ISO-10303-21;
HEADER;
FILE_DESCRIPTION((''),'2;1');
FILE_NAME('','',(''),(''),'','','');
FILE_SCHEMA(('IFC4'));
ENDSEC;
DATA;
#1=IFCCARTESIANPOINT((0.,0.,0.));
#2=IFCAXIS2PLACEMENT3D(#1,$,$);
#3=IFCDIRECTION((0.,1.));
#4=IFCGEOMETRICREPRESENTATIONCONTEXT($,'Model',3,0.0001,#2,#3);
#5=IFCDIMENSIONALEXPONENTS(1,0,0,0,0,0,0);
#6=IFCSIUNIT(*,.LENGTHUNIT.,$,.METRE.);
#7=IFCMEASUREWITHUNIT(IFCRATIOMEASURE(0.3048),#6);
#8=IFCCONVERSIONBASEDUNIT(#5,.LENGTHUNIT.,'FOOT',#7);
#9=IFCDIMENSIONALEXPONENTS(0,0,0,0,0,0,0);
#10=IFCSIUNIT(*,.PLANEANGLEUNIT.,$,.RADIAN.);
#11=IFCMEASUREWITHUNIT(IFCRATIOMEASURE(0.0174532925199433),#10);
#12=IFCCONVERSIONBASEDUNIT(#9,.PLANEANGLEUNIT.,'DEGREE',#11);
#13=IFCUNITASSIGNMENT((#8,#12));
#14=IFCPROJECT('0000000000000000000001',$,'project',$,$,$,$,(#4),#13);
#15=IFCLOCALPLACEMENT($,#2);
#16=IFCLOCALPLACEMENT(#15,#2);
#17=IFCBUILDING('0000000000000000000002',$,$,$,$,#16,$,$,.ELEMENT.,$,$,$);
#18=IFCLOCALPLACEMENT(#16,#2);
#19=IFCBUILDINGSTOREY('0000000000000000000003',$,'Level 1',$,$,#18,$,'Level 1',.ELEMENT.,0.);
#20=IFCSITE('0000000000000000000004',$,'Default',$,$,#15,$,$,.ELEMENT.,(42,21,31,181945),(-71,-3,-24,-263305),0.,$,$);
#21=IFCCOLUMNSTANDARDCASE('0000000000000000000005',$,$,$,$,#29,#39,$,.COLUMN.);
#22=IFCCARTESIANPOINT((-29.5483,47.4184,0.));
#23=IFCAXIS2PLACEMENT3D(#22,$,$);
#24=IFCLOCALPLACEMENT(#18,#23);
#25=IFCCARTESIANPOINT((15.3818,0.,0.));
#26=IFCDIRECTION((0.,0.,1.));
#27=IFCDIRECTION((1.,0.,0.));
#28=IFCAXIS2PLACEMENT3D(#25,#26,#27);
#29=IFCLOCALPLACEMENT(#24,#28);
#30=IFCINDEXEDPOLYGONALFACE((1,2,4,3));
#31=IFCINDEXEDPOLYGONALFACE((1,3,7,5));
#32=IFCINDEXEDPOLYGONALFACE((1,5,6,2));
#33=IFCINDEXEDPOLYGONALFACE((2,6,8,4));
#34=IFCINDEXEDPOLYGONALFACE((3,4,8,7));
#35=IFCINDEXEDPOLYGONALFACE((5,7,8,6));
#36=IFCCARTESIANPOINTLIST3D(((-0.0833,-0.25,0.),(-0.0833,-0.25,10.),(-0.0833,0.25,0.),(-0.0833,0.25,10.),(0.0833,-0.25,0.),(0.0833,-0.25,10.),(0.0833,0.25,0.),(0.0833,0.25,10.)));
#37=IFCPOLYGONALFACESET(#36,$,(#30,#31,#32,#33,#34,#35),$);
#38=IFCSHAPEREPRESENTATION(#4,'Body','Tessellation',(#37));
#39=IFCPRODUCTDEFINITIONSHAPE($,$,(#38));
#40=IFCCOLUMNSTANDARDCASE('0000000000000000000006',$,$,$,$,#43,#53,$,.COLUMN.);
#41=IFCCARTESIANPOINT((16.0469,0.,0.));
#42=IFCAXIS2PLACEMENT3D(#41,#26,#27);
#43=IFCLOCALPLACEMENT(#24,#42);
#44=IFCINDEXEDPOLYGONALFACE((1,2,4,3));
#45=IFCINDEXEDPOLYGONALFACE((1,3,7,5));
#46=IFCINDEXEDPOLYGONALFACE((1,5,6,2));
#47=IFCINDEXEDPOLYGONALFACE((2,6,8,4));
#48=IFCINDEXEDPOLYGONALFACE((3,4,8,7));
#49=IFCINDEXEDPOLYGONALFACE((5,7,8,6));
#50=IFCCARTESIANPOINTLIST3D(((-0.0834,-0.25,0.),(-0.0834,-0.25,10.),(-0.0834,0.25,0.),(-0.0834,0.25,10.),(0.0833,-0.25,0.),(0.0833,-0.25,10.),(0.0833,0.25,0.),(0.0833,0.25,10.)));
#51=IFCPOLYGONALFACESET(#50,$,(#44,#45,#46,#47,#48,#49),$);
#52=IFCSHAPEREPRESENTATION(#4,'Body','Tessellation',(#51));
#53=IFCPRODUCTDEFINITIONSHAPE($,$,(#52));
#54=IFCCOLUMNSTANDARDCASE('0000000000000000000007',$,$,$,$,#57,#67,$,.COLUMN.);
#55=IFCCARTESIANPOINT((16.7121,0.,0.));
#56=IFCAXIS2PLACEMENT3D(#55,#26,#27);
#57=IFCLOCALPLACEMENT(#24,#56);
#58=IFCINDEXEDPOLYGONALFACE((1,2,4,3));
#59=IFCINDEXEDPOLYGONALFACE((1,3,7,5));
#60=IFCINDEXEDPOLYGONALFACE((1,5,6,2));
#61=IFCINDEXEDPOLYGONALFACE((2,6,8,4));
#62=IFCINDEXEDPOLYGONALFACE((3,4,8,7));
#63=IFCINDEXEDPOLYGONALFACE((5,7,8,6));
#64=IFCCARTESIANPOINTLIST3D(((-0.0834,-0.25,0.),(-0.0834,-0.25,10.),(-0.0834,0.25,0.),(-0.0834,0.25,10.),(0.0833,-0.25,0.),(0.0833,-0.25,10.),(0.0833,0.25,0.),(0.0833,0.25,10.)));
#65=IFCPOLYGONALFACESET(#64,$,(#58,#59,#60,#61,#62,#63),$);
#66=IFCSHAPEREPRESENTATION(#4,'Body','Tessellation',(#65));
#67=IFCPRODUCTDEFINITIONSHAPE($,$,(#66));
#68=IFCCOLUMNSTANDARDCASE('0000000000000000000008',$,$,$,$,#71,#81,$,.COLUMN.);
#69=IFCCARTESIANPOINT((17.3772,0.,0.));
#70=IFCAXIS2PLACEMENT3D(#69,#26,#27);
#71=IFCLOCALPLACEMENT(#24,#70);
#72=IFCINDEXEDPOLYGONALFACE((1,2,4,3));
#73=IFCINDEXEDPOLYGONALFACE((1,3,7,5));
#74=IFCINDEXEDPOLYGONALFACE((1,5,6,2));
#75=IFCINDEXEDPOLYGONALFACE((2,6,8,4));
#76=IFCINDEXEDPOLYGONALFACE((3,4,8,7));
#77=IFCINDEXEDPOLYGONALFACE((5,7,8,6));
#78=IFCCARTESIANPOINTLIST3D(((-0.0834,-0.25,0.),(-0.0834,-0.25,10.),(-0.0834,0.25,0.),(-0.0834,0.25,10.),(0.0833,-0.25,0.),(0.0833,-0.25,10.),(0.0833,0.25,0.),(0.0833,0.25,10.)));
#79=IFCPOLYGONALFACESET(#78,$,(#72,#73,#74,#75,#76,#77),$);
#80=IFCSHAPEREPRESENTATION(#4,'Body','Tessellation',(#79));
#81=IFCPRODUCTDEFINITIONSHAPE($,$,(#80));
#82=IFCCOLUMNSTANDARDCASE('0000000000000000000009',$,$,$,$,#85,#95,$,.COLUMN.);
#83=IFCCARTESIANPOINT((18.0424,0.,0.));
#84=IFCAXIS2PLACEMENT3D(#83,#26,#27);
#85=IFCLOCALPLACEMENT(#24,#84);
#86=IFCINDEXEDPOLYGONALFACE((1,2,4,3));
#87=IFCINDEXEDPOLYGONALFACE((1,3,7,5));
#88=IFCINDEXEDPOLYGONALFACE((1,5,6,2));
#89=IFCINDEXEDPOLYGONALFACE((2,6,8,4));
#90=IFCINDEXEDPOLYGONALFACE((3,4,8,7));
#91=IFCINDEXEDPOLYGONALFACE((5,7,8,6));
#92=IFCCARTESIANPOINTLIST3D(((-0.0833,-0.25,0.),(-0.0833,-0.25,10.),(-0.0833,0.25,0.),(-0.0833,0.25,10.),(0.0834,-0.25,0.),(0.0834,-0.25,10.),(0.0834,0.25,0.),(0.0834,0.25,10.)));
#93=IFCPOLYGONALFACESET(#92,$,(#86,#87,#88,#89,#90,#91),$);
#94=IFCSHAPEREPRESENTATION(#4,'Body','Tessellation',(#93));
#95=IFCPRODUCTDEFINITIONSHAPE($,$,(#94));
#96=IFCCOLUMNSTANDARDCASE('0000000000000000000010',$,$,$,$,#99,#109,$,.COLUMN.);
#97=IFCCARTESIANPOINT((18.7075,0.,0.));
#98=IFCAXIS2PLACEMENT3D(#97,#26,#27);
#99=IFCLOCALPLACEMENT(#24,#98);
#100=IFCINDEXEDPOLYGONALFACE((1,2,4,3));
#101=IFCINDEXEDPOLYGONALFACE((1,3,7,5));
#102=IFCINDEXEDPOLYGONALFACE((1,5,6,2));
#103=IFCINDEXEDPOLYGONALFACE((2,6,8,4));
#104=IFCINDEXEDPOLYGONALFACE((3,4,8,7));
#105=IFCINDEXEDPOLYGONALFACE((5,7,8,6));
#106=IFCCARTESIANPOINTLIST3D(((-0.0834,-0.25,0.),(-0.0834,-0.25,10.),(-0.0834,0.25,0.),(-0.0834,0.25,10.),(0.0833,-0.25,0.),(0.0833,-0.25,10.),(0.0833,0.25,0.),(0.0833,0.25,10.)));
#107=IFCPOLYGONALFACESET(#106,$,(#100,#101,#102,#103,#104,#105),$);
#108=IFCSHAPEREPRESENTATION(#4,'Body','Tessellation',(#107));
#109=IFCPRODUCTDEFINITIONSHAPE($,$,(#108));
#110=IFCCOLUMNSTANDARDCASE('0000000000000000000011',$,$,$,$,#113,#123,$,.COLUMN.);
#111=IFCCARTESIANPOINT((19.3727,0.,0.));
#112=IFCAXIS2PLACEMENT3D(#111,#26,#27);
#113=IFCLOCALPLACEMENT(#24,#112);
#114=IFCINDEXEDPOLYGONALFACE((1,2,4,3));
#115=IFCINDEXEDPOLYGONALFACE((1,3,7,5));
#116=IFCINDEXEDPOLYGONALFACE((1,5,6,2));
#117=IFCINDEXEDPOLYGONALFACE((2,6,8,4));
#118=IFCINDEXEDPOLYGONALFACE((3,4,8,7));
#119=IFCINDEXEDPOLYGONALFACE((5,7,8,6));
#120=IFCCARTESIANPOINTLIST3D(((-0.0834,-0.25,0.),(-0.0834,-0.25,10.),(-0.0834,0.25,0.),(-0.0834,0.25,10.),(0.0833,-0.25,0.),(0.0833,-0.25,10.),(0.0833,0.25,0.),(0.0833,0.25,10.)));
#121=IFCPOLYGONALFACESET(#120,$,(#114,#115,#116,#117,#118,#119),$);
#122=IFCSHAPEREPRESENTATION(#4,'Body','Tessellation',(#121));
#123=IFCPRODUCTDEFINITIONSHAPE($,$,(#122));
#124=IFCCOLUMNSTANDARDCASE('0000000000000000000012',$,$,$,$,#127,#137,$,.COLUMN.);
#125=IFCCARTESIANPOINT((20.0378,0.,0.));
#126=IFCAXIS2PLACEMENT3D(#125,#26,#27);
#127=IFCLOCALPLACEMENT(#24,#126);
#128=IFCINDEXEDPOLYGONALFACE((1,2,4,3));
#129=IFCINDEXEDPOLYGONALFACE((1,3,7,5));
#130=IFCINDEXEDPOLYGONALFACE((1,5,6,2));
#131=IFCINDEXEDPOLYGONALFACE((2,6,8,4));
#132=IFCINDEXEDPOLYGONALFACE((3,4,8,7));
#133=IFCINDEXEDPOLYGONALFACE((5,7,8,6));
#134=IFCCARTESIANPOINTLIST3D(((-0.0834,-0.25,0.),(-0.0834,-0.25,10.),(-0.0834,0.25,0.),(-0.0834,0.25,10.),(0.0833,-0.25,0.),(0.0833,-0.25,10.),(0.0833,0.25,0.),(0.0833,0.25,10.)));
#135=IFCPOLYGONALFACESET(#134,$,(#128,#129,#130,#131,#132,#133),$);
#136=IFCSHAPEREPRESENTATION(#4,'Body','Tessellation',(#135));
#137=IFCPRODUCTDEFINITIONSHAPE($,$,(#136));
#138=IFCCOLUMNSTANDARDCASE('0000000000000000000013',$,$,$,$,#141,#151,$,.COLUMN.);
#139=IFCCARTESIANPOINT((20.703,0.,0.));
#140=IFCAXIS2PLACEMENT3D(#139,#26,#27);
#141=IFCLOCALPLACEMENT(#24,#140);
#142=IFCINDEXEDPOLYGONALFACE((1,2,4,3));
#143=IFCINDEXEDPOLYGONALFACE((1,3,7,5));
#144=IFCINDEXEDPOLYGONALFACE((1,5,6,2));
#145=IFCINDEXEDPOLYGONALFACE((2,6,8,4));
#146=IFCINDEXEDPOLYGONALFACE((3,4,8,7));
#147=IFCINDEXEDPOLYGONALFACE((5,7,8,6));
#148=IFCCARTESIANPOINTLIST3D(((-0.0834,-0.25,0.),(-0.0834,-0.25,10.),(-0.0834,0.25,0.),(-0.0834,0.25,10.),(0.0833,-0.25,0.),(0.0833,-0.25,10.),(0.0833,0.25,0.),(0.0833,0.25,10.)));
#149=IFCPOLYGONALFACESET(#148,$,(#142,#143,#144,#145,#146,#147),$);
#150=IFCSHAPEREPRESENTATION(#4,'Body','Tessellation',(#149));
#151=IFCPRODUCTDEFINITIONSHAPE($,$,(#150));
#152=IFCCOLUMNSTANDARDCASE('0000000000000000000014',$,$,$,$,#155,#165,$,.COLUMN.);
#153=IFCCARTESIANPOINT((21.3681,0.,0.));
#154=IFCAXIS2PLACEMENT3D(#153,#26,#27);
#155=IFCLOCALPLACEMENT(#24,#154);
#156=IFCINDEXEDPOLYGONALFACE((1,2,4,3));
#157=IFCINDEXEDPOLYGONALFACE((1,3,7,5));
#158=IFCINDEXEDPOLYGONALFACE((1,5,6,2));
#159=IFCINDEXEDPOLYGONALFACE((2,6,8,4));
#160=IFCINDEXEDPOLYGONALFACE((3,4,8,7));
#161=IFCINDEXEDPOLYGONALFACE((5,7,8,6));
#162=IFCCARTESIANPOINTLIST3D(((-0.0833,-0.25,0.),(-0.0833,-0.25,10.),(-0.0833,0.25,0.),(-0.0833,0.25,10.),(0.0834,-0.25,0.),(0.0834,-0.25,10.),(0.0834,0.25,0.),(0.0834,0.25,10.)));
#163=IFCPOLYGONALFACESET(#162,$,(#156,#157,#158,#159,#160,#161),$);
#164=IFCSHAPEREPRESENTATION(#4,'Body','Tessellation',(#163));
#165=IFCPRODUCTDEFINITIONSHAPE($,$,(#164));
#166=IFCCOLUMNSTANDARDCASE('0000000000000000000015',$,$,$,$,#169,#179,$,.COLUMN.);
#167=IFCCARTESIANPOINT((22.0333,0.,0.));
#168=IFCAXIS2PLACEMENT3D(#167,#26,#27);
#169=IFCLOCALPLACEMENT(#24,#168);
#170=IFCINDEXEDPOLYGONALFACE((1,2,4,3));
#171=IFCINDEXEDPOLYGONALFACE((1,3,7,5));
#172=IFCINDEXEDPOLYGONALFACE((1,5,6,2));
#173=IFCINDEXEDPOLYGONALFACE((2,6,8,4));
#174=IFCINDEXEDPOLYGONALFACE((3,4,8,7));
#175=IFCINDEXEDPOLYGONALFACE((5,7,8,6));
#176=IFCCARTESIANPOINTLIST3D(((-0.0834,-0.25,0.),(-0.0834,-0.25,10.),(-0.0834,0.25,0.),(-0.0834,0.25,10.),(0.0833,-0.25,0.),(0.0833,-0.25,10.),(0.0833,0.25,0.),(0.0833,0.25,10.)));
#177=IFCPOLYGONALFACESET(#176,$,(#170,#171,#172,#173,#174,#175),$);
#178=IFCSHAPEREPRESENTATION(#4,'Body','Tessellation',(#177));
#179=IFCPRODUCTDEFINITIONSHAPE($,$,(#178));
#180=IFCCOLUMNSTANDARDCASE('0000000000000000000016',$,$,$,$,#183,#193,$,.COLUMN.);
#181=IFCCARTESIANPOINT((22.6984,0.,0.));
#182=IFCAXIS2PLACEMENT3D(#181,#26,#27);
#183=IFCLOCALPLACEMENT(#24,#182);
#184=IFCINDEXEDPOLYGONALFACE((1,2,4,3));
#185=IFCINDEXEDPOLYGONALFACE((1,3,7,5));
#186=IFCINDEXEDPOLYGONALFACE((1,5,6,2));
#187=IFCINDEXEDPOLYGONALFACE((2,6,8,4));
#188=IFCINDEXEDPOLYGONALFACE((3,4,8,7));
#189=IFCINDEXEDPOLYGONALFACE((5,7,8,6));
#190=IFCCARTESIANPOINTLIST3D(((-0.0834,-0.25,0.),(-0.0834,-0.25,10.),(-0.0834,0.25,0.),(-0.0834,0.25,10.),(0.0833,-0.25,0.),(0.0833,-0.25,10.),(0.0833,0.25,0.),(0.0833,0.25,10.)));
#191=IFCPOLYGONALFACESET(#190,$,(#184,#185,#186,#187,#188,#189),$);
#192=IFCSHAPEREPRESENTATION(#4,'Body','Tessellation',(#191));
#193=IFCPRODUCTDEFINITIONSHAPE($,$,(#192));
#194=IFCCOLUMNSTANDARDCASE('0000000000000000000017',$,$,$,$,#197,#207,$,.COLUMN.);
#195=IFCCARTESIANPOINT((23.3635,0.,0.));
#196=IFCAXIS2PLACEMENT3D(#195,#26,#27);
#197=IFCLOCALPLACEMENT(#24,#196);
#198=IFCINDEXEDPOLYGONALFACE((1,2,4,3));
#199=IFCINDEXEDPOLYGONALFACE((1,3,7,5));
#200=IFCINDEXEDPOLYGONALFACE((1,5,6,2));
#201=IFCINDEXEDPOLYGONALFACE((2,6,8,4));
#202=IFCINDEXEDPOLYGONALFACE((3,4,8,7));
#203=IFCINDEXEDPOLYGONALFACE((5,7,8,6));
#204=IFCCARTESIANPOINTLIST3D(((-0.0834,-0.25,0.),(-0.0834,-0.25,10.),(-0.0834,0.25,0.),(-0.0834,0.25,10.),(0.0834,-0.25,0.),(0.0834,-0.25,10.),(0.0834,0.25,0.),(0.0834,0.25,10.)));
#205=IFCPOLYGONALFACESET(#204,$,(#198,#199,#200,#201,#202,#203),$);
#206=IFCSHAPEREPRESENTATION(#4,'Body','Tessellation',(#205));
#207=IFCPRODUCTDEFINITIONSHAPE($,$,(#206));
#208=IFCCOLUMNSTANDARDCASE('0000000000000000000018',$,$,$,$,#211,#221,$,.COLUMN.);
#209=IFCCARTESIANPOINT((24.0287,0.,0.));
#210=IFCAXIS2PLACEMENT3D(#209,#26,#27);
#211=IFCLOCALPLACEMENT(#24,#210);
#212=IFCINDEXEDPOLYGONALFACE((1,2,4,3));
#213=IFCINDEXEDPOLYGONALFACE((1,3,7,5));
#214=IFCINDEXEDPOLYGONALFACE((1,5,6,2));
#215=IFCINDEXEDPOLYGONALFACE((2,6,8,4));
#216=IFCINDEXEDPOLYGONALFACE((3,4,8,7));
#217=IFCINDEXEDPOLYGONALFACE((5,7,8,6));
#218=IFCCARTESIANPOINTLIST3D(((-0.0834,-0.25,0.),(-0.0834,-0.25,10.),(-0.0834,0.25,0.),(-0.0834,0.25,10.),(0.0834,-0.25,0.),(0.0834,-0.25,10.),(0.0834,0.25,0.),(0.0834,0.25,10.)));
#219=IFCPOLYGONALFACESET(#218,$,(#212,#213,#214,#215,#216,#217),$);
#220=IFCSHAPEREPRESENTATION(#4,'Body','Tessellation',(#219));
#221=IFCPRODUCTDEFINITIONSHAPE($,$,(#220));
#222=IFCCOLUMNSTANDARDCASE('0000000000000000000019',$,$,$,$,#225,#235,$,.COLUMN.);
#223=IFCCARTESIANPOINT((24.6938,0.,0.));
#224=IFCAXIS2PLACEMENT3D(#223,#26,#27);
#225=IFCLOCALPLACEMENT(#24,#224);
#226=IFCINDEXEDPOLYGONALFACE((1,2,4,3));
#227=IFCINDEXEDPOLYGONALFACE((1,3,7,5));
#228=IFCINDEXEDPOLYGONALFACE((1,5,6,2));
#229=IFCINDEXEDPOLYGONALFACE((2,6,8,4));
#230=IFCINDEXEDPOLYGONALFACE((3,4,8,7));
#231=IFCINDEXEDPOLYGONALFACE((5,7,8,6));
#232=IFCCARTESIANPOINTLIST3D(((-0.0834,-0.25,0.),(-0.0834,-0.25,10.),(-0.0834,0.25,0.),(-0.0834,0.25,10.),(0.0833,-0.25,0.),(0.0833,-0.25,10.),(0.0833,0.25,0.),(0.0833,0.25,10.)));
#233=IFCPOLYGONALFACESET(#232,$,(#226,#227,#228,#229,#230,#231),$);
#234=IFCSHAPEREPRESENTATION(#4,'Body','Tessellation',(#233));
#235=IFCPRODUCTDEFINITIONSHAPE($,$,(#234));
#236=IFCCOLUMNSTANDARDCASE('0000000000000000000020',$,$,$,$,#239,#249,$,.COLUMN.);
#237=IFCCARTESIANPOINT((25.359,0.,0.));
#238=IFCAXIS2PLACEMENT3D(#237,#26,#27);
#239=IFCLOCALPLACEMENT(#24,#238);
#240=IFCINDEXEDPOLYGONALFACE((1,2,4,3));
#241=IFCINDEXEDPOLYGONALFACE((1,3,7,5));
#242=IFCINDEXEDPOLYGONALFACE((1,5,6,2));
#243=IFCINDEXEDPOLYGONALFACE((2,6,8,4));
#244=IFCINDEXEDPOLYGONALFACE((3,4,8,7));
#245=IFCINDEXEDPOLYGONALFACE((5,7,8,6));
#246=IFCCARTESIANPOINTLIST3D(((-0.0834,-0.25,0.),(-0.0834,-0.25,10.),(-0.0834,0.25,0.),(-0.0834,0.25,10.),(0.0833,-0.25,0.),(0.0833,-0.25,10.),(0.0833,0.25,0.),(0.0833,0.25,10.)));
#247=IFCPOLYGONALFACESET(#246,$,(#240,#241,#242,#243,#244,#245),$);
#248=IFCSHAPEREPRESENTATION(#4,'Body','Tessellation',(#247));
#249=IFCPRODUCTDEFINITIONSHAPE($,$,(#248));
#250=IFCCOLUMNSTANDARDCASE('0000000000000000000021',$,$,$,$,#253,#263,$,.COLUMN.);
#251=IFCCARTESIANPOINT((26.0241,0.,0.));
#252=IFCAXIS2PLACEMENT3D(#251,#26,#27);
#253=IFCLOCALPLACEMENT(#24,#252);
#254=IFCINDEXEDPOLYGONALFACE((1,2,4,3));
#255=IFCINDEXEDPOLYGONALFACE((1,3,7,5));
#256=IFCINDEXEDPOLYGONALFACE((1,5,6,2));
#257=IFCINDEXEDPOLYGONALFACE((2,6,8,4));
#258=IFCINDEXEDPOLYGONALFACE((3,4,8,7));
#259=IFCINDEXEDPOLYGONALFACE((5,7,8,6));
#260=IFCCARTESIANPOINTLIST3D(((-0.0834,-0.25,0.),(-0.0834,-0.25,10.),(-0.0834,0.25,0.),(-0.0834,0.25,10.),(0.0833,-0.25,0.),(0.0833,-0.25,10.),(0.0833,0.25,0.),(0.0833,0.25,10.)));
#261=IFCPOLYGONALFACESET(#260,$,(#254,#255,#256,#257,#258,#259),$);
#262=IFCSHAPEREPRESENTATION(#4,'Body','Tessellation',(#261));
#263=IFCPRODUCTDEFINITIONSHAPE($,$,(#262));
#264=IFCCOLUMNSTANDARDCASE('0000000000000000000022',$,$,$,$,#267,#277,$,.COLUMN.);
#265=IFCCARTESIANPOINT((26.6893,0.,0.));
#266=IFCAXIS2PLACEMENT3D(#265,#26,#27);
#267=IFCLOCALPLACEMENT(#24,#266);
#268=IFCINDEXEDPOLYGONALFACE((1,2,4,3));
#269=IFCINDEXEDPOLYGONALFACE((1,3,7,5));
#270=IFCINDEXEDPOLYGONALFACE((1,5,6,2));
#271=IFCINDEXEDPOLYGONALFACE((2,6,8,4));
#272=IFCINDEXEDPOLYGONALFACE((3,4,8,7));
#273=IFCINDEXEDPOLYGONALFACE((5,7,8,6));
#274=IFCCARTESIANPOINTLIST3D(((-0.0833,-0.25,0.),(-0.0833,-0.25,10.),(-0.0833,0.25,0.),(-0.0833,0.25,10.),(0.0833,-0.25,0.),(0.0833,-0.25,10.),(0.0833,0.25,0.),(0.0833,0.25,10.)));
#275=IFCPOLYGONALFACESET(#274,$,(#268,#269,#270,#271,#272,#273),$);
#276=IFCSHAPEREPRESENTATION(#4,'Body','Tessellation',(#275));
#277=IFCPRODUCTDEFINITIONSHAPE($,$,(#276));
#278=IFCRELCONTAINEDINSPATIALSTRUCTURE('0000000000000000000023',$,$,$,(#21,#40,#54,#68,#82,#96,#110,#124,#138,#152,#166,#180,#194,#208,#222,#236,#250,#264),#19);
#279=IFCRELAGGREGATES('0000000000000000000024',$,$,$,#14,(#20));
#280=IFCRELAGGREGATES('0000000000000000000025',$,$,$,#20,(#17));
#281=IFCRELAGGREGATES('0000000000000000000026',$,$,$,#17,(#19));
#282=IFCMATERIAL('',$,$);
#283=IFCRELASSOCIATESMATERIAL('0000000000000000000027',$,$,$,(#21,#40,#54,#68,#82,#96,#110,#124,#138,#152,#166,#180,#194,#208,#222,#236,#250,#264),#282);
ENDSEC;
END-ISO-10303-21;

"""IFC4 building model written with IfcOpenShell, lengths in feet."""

from ifc_helpers import new_model, entity, si_unit, converted_unit, direction, frame, origin, place, context, project, spatial, rectangle, extrude, material, element, save


model = new_model("IFC4")

# Units and contexts
model_context = context("Model", 3, precision=0.0001, world=origin(), true_north=direction((0.0, 1.0)))
ifc_project = project(units=[converted_unit("LENGTHUNIT", "FOOT", entity("IfcRatioMeasure", 0.3048), si_unit("LENGTHUNIT", "METRE"), dimensions=[1, 0, 0, 0, 0, 0, 0]), converted_unit("PLANEANGLEUNIT", "DEGREE", entity("IfcRatioMeasure", 0.0174532925199433), si_unit("PLANEANGLEUNIT", "RADIAN"), dimensions=[0, 0, 0, 0, 0, 0, 0])], contexts=[model_context])

# Site, building, storey
site_placement = place(None, origin())
site = spatial("IfcSite", under=ifc_project, at=site_placement, Name="Default", CompositionType="ELEMENT", RefLatitude=(42, 21, 31, 181945), RefLongitude=(-71, -3, -24, -263305), RefElevation=0.0)
building_placement = place(site_placement, origin())
building = spatial("IfcBuilding", under=site, at=building_placement, CompositionType="ELEMENT")
storey_placement = place(building_placement, origin())
storey = spatial("IfcBuildingStorey", under=building, at=storey_placement, Name="Level 1", LongName="Level 1", CompositionType="ELEMENT", Elevation=0.0)

# Columns
ifc_material = material(Name="")
placement = place(storey_placement, frame((-29.5483, 47.4184, 0.0)))
for number, where, z_axis, x_axis in (
    (1, (15.3818, 0.0, 0.0), (0.0, 0.0, 1.0), (1.0, 0.0, 0.0)),
    (2, (16.0469, 0.0, 0.0), (0.0, 0.0, 1.0), (1.0, 0.0, 0.0)),
    (3, (16.7121, 0.0, 0.0), (0.0, 0.0, 1.0), (1.0, 0.0, 0.0)),
    (4, (17.3772, 0.0, 0.0), (0.0, 0.0, 1.0), (1.0, 0.0, 0.0)),
    (5, (18.0424, 0.0, 0.0), (0.0, 0.0, 1.0), (1.0, 0.0, 0.0)),
    (6, (18.7075, 0.0, 0.0), (0.0, 0.0, 1.0), (1.0, 0.0, 0.0)),
    (7, (19.3727, 0.0, 0.0), (0.0, 0.0, 1.0), (1.0, 0.0, 0.0)),
    (8, (20.0378, 0.0, 0.0), (0.0, 0.0, 1.0), (1.0, 0.0, 0.0)),
    (9, (20.703, 0.0, 0.0), (0.0, 0.0, 1.0), (1.0, 0.0, 0.0)),
    (10, (21.3681, 0.0, 0.0), (0.0, 0.0, 1.0), (1.0, 0.0, 0.0)),
    (11, (22.0333, 0.0, 0.0), (0.0, 0.0, 1.0), (1.0, 0.0, 0.0)),
    (12, (22.6984, 0.0, 0.0), (0.0, 0.0, 1.0), (1.0, 0.0, 0.0)),
    (13, (23.3635, 0.0, 0.0), (0.0, 0.0, 1.0), (1.0, 0.0, 0.0)),
    (14, (24.0287, 0.0, 0.0), (0.0, 0.0, 1.0), (1.0, 0.0, 0.0)),
    (15, (24.6938, 0.0, 0.0), (0.0, 0.0, 1.0), (1.0, 0.0, 0.0)),
    (16, (25.359, 0.0, 0.0), (0.0, 0.0, 1.0), (1.0, 0.0, 0.0)),
    (17, (26.0241, 0.0, 0.0), (0.0, 0.0, 1.0), (1.0, 0.0, 0.0)),
    (18, (26.6893, 0.0, 0.0), (0.0, 0.0, 1.0), (1.0, 0.0, 0.0)),
):
    element("IfcColumnStandardCase", number, at=place(placement, frame(where, z_axis=z_axis, x_axis=x_axis)), inside=storey, material=ifc_material, PredefinedType="COLUMN", context=model_context, shape_type="SweptSolid", body=[
        extrude(rectangle(XDim=0.1667, YDim=0.5), origin(), (0.0, 0.0, 1.0), 10.0),
    ])

save(model, "model.ifc")
